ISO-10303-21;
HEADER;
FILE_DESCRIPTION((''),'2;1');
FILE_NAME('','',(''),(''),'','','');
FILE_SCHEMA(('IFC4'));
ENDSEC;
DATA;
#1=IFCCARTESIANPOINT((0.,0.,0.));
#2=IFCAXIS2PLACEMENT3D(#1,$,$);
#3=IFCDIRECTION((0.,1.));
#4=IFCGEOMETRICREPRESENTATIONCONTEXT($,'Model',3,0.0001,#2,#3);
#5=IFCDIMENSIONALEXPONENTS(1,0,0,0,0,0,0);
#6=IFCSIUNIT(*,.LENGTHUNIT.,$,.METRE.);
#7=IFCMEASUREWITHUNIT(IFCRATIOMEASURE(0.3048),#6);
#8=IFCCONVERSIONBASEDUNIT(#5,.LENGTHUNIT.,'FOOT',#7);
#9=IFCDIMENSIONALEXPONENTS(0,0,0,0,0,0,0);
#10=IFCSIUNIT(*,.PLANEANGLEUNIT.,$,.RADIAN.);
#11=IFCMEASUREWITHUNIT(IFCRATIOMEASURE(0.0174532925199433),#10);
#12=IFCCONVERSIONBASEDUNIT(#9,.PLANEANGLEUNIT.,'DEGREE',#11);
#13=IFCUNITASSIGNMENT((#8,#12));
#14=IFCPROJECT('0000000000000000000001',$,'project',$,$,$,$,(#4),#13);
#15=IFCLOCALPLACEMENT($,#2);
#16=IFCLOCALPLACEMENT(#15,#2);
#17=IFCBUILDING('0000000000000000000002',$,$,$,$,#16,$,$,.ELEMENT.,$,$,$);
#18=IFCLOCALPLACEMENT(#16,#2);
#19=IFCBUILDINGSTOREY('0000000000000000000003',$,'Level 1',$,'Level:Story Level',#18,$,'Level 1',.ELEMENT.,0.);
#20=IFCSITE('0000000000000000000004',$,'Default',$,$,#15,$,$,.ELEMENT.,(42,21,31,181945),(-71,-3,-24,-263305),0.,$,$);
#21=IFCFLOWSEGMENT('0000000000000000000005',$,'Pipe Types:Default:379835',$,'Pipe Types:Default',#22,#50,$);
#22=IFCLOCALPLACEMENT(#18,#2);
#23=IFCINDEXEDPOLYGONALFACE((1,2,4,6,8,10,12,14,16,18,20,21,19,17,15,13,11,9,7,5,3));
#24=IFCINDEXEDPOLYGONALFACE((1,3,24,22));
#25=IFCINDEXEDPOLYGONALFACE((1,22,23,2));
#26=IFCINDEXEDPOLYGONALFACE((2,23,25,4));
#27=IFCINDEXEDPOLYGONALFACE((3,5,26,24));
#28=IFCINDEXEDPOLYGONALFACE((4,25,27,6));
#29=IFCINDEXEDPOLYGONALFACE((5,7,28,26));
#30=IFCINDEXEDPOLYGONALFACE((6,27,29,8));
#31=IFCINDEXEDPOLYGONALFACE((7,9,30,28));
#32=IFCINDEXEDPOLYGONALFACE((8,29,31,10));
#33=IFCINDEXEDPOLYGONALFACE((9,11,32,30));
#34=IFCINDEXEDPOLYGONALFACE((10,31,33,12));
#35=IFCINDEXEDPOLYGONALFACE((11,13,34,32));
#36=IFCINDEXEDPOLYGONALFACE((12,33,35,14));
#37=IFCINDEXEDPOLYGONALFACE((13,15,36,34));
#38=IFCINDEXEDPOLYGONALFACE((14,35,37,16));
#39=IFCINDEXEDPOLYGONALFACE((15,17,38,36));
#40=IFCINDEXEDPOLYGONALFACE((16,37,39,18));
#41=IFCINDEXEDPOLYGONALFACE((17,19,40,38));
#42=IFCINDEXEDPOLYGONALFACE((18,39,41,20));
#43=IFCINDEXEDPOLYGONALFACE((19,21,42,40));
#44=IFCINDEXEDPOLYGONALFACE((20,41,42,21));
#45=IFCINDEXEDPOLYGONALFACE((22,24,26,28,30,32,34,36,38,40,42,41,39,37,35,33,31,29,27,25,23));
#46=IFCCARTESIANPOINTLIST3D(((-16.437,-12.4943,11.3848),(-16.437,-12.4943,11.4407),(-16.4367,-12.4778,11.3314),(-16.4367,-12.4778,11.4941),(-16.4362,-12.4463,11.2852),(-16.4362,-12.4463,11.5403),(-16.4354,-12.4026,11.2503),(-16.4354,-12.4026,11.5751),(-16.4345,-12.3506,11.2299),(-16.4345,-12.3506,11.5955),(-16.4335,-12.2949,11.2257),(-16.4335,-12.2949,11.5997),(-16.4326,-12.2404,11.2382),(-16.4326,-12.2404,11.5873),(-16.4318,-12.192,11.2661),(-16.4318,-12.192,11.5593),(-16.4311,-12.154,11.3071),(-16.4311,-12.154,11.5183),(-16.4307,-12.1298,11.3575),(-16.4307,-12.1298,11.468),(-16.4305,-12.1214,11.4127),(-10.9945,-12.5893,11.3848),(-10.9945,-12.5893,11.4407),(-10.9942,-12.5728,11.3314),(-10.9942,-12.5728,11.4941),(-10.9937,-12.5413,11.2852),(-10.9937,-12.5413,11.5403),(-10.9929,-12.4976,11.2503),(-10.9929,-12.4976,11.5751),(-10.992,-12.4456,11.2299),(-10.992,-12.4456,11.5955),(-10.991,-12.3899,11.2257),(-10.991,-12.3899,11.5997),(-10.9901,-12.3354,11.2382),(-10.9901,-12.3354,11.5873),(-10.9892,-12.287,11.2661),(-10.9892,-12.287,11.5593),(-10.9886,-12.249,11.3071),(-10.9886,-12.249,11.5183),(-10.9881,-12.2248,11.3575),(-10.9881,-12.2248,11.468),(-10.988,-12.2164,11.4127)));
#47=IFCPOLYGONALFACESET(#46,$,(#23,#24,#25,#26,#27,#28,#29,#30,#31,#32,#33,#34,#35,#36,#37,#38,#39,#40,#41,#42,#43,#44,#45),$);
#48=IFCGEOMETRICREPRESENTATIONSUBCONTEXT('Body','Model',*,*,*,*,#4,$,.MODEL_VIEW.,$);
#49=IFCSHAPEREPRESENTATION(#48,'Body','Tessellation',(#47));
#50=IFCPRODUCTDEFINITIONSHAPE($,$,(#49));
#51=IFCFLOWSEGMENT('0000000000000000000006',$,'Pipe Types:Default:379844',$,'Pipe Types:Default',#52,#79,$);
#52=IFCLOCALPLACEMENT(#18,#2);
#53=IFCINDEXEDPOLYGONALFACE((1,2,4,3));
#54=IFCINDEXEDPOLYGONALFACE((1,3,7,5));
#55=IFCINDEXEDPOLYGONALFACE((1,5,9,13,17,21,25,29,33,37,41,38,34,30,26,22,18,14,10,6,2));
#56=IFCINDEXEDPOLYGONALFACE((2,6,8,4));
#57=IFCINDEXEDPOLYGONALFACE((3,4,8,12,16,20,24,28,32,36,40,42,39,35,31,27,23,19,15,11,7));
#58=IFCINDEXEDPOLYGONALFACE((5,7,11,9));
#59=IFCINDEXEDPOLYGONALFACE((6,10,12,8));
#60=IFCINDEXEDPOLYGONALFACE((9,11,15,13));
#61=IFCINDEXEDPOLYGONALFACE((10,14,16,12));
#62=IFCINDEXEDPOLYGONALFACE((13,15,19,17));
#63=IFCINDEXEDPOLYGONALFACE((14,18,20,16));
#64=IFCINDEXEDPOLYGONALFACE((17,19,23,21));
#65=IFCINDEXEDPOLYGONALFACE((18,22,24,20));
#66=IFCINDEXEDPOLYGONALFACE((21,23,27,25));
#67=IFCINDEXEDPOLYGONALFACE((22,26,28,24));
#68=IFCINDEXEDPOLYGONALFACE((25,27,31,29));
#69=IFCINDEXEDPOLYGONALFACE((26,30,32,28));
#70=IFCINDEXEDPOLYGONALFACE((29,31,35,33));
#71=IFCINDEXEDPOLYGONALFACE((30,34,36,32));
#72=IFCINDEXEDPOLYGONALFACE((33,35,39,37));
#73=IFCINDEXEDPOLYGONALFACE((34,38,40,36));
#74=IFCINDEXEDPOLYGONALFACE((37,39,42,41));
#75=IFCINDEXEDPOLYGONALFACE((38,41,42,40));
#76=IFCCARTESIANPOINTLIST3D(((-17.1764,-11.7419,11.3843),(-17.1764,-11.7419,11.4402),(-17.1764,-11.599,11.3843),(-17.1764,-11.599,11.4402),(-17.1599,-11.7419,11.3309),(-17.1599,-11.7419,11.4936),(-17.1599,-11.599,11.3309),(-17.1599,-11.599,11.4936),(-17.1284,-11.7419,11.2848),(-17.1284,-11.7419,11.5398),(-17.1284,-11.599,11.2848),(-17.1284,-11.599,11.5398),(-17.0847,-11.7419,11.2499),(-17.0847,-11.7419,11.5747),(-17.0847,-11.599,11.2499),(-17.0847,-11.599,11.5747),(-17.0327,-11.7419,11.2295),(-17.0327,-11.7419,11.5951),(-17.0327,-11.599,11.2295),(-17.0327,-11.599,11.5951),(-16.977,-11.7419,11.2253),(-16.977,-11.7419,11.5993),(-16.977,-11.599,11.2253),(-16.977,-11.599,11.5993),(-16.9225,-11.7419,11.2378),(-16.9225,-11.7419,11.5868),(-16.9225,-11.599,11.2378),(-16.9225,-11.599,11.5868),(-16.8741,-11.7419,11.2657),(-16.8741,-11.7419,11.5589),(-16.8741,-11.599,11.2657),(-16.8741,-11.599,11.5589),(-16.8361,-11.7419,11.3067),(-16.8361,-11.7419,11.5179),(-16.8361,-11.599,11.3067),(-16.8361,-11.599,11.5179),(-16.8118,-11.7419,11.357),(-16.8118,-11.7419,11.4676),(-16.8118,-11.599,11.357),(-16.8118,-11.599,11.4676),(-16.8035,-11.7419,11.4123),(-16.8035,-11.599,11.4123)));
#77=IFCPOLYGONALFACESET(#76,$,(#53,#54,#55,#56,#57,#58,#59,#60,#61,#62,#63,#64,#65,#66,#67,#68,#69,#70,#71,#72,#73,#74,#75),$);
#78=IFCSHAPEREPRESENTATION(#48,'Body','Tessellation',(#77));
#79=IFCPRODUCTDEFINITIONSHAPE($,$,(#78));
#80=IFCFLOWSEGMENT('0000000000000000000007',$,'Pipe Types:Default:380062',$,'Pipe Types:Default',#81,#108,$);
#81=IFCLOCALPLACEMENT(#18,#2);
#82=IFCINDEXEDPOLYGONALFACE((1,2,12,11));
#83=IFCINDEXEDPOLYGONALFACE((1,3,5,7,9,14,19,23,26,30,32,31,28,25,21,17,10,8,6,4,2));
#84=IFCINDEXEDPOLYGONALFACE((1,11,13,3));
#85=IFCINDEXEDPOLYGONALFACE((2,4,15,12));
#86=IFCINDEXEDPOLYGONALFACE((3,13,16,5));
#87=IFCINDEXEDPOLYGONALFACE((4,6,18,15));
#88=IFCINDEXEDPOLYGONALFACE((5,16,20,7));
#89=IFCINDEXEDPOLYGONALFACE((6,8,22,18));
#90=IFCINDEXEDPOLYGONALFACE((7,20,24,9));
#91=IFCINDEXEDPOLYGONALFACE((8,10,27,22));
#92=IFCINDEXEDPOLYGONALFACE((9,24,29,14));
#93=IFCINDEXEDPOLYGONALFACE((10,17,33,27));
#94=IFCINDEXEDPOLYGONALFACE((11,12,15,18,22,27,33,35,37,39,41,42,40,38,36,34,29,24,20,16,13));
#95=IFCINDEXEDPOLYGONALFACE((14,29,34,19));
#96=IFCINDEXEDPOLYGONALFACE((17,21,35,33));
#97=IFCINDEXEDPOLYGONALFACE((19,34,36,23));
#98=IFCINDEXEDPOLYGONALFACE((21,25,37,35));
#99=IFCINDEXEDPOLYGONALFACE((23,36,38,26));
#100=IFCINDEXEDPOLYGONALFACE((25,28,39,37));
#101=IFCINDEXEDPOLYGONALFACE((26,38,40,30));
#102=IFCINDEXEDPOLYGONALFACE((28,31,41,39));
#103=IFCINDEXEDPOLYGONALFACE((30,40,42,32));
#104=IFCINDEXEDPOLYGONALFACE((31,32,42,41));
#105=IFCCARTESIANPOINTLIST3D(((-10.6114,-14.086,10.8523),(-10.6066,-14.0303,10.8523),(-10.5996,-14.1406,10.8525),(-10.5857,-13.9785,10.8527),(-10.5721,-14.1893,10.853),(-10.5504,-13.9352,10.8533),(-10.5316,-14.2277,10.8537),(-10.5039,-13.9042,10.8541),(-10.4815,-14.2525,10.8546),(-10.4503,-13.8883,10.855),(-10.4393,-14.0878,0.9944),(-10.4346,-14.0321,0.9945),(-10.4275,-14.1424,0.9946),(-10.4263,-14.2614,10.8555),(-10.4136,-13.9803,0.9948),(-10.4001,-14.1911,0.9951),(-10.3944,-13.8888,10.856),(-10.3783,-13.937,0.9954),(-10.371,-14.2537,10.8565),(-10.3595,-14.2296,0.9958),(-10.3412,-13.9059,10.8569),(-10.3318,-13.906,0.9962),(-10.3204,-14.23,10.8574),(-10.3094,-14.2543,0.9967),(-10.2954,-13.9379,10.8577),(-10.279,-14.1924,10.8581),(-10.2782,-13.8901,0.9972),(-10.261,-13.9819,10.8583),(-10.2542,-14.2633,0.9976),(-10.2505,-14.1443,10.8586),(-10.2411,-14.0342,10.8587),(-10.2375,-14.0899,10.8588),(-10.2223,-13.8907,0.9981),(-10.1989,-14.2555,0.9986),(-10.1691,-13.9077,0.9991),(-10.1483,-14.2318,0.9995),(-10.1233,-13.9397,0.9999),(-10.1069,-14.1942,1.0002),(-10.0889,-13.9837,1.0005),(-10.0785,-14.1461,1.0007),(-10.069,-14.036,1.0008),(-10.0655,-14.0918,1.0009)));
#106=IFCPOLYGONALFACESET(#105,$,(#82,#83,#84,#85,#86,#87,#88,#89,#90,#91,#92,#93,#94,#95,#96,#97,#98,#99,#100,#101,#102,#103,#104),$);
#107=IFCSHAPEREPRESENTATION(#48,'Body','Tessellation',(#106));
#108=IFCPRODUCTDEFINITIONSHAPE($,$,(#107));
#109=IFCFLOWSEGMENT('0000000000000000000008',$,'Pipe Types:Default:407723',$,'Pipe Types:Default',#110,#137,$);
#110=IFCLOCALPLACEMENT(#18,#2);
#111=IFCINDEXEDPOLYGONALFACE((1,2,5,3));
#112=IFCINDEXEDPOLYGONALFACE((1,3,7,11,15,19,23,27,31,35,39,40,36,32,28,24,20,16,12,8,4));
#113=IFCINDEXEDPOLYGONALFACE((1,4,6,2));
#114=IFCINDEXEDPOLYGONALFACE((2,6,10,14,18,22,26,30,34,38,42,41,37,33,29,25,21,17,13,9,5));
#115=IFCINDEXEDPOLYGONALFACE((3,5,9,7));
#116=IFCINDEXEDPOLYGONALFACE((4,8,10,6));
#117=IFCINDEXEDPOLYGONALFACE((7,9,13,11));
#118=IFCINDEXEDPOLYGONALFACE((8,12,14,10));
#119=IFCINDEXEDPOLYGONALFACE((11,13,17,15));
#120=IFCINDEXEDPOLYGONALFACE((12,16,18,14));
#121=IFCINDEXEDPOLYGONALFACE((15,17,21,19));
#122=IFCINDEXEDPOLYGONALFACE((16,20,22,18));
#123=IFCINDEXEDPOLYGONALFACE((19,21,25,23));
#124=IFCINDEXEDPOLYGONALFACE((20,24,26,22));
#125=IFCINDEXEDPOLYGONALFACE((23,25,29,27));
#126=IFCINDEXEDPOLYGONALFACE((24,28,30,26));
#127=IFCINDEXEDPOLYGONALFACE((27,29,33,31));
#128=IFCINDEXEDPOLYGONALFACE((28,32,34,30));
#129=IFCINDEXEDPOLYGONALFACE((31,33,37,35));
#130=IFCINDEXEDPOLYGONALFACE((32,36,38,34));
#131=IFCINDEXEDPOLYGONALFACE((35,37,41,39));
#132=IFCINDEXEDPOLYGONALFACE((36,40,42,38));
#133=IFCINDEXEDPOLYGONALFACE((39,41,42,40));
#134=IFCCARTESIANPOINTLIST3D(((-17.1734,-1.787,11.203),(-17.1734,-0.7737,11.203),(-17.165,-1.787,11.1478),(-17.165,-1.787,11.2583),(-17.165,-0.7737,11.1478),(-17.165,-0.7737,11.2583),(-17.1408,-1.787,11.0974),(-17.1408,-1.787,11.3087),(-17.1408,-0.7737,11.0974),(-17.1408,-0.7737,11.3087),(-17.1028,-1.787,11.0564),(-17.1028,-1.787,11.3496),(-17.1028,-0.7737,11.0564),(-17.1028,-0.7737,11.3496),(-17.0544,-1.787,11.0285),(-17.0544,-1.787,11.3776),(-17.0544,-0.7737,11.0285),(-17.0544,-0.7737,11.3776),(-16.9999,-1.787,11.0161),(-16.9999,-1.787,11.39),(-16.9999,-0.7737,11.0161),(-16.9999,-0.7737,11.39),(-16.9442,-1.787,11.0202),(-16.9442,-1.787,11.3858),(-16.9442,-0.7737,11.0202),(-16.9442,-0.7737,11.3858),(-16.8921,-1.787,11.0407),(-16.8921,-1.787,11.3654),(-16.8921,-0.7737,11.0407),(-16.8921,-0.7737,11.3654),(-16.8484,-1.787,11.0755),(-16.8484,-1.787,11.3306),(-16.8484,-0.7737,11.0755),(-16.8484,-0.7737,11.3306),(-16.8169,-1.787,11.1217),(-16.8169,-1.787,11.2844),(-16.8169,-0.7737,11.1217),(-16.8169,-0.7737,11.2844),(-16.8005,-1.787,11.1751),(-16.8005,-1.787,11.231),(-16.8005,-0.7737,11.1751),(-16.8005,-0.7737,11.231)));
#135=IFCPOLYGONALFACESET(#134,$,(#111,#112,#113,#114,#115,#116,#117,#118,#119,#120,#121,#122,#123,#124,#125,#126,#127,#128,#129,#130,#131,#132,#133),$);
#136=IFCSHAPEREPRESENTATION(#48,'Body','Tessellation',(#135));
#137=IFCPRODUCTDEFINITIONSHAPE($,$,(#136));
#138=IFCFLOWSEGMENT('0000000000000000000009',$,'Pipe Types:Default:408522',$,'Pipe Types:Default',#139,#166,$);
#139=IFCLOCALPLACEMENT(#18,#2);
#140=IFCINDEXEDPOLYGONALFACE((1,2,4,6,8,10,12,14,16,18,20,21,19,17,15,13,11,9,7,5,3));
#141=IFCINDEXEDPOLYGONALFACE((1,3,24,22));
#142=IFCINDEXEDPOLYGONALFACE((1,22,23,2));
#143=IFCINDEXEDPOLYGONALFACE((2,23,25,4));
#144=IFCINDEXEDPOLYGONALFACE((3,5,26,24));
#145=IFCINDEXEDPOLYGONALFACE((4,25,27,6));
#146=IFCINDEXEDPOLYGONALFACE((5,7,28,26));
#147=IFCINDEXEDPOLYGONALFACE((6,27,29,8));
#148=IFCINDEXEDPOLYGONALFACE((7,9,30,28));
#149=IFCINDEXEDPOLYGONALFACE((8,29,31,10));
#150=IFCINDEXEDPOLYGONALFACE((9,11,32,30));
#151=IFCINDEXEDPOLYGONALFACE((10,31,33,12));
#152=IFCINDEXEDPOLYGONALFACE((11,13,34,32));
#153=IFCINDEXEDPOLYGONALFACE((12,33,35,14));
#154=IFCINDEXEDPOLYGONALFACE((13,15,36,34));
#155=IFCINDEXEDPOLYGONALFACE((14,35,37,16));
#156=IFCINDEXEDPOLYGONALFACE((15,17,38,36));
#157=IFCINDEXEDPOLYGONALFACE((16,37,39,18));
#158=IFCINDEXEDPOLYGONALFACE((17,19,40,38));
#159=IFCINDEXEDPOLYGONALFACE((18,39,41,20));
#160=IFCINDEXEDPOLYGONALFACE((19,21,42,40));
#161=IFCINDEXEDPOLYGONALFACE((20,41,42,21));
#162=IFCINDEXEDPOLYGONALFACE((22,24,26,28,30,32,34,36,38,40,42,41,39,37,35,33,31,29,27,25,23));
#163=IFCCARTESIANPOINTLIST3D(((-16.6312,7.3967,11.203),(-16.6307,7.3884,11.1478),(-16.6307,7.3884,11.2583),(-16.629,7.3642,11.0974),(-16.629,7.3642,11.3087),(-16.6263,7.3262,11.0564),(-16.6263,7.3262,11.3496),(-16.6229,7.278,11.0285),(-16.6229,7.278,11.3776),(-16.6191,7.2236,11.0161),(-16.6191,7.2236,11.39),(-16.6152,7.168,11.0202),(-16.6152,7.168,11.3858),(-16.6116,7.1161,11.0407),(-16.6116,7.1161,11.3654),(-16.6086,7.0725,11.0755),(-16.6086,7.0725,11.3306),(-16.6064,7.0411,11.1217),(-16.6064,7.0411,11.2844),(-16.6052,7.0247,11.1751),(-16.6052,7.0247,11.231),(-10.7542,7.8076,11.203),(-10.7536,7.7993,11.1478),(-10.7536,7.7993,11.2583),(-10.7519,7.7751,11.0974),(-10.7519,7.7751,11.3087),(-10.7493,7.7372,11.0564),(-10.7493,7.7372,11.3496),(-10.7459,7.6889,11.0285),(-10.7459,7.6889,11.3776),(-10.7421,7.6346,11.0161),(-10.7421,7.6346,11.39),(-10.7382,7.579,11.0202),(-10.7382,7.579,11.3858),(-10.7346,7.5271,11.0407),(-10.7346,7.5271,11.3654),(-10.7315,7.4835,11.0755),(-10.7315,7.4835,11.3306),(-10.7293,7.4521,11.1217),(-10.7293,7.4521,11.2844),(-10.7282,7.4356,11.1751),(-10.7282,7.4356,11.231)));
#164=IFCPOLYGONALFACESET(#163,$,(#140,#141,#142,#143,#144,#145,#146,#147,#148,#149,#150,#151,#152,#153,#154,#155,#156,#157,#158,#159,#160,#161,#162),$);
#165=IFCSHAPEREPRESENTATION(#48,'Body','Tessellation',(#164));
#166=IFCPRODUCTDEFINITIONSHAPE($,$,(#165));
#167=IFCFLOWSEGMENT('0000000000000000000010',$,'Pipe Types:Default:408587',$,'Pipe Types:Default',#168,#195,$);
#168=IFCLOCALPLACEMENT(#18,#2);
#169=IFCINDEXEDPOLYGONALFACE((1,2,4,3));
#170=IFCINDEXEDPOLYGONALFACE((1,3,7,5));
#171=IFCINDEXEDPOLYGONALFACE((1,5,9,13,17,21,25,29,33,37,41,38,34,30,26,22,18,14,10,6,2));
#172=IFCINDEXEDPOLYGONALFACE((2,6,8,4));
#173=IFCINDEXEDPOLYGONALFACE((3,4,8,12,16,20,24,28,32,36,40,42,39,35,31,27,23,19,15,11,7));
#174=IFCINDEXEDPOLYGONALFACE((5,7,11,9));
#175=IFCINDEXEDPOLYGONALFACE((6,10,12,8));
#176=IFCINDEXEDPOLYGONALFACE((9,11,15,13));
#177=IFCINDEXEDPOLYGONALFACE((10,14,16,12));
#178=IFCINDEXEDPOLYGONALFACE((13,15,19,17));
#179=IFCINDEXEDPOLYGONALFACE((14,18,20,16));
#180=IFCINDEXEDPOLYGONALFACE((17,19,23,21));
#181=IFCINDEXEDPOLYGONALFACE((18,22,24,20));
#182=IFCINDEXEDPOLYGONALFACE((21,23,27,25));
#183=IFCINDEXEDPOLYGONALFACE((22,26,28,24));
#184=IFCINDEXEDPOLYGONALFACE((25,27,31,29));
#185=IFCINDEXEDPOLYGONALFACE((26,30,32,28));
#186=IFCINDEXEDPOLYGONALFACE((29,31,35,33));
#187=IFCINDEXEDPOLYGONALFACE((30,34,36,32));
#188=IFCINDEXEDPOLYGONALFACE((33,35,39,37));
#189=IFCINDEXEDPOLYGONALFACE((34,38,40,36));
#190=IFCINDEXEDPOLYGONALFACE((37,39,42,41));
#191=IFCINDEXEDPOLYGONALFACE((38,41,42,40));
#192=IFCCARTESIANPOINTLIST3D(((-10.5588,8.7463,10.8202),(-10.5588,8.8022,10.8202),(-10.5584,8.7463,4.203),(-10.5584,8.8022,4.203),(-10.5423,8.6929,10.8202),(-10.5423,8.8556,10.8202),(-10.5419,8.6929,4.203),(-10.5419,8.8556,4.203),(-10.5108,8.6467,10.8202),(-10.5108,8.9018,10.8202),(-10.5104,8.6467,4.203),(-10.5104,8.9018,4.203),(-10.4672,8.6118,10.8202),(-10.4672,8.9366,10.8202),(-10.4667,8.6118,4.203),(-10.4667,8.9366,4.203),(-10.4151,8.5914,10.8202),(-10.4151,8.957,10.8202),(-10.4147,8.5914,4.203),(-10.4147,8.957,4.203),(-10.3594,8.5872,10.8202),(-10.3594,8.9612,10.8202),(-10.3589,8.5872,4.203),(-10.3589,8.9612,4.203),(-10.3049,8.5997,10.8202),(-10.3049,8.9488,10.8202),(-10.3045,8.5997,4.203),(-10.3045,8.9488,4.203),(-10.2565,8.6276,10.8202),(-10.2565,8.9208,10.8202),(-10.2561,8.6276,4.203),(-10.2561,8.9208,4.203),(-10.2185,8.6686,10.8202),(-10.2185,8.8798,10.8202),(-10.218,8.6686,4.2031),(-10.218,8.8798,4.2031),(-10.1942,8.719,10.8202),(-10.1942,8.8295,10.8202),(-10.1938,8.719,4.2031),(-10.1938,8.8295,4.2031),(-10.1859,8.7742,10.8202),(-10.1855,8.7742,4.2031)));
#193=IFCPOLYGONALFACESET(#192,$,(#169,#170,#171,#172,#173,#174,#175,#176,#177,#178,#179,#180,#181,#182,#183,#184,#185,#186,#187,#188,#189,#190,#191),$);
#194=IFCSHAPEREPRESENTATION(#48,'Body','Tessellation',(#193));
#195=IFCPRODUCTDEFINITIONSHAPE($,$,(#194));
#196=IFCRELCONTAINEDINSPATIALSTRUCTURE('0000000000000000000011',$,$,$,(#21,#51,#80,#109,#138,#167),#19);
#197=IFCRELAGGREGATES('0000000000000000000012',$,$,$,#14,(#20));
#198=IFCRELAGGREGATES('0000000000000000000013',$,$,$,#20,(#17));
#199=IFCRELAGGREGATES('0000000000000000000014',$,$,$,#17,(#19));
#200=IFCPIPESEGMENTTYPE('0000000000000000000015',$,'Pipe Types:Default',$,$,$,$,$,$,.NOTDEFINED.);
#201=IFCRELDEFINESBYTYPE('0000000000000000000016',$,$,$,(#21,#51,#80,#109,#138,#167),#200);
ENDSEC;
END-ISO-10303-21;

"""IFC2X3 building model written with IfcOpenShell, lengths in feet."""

from ifc_helpers import new_model, entity, si_unit, converted_unit, direction, frame, frame_2d, origin, place, context, subcontext, project, spatial, circle, extrude, type_object, element, save


model = new_model("IFC2X3")

# Units and contexts
model_context = context("Model", 3, precision=0.0001, world=origin(), true_north=direction((0.0, 1.0)))
body_context = subcontext(model_context, "Body", "Model", "MODEL_VIEW")
ifc_project = project(units=[converted_unit("LENGTHUNIT", "FOOT", entity("IfcRatioMeasure", 0.3048), si_unit("LENGTHUNIT", "METRE"), dimensions=[1, 0, 0, 0, 0, 0, 0]), converted_unit("PLANEANGLEUNIT", "DEGREE", entity("IfcRatioMeasure", 0.0174532925199433), si_unit("PLANEANGLEUNIT", "RADIAN"), dimensions=[0, 0, 0, 0, 0, 0, 0])], contexts=[model_context])

# Site, building, storey
site_placement = place(None, origin())
site = spatial("IfcSite", under=ifc_project, at=site_placement, Name="Default", CompositionType="ELEMENT", RefLatitude=(42, 21, 31, 181945), RefLongitude=(-71, -3, -24, -263305), RefElevation=0.0)
building_placement = place(site_placement, origin())
building = spatial("IfcBuilding", under=site, at=building_placement, CompositionType="ELEMENT")
storey_placement = place(building_placement, origin())
storey = spatial("IfcBuildingStorey", under=building, at=storey_placement, Name="Level 1", ObjectType="Level:Story Level", LongName="Level 1", CompositionType="ELEMENT", Elevation=0.0)

# Flow segments
pipe_segment_type = type_object("IfcPipeSegmentType", Name="Pipe Types:Default", PredefinedType="NOTDEFINED")
flow_segment_1_placement = place(storey_placement, origin())
element("IfcFlowSegment", 1, at=flow_segment_1_placement, inside=storey, type_object=pipe_segment_type, Name="Pipe Types:Default:379835", ObjectType="Pipe Types:Default", context=body_context, shape_type="SweptSolid", body=[
    extrude(circle(Radius=0.1875, at=frame_2d((0.0, 0.0), x_axis=(1.0, 0.0))), frame((-10.9913, -12.4039, 11.4127), z_axis=(-0.999848, 0.017452, 0.0), x_axis=(0.017452, 0.999848, 0.0)), (0.0, 0.0, 1.0), 5.4434),
])
flow_segment_2_placement = place(storey_placement, origin())
element("IfcFlowSegment", 2, at=flow_segment_2_placement, inside=storey, type_object=pipe_segment_type, Name="Pipe Types:Default:379844", ObjectType="Pipe Types:Default", context=body_context, shape_type="SweptSolid", body=[
    extrude(circle(Radius=0.1875, at=frame_2d((0.0, 0.0), x_axis=(1.0, 0.0))), frame((-16.991, -11.7419, 11.4123), z_axis=(0.0, 1.0, 0.0), x_axis=(1.0, 0.0, 0.0)), (0.0, 0.0, 1.0), 0.1429),
])
flow_segment_3_placement = place(storey_placement, origin())
element("IfcFlowSegment", 3, at=flow_segment_3_placement, inside=storey, type_object=pipe_segment_type, Name="Pipe Types:Default:380062", ObjectType="Pipe Types:Default", context=body_context, shape_type="SweptSolid", body=[
    extrude(circle(Radius=0.1875, at=frame_2d((0.0, 0.0), x_axis=(1.0, 0.0))), frame((-10.4243, -14.0739, 10.8555), z_axis=(0.017452, -0.000185, -0.999848), x_axis=(-0.010613, -0.999944, 0.0)), (0.0, 0.0, 1.0), 9.8594),
])
flow_segment_4_placement = place(storey_placement, origin())
element("IfcFlowSegment", 4, at=flow_segment_4_placement, inside=storey, type_object=pipe_segment_type, Name="Pipe Types:Default:407723", ObjectType="Pipe Types:Default", context=body_context, shape_type="SweptSolid", body=[
    extrude(circle(Radius=0.1875, at=frame_2d((0.0, 0.0), x_axis=(1.0, 0.0))), frame((-16.9859, -1.787, 11.203), z_axis=(0.0, 1.0, 0.0), x_axis=(-1.0, 0.0, 0.0)), (0.0, 0.0, 1.0), 1.0133),
])
flow_segment_5_placement = place(storey_placement, origin())
element("IfcFlowSegment", 5, at=flow_segment_5_placement, inside=storey, type_object=pipe_segment_type, Name="Pipe Types:Default:408522", ObjectType="Pipe Types:Default", context=body_context, shape_type="SweptSolid", body=[
    extrude(circle(Radius=0.1875, at=frame_2d((0.0, 0.0), x_axis=(1.0, 0.0))), frame((-16.6182, 7.2096, 11.203), z_axis=(0.997564, 0.069756, 0.0), x_axis=(-0.069756, 0.997564, 0.0)), (0.0, 0.0, 1.0), 5.8914),
])
flow_segment_6_placement = place(storey_placement, origin())
element("IfcFlowSegment", 6, at=flow_segment_6_placement, inside=storey, type_object=pipe_segment_type, Name="Pipe Types:Default:408587", ObjectType="Pipe Types:Default", context=body_context, shape_type="SweptSolid", body=[
    extrude(circle(Radius=0.1875, at=frame_2d((0.0, 0.0), x_axis=(1.0, 0.0))), frame((-10.373, 8.7742, 4.203), z_axis=(-0.000067, 0.0, 1.0), x_axis=(1.0, 0.0, 0.000067)), (0.0, 0.0, 1.0), 6.6171),
])

save(model, "model.ifc")
